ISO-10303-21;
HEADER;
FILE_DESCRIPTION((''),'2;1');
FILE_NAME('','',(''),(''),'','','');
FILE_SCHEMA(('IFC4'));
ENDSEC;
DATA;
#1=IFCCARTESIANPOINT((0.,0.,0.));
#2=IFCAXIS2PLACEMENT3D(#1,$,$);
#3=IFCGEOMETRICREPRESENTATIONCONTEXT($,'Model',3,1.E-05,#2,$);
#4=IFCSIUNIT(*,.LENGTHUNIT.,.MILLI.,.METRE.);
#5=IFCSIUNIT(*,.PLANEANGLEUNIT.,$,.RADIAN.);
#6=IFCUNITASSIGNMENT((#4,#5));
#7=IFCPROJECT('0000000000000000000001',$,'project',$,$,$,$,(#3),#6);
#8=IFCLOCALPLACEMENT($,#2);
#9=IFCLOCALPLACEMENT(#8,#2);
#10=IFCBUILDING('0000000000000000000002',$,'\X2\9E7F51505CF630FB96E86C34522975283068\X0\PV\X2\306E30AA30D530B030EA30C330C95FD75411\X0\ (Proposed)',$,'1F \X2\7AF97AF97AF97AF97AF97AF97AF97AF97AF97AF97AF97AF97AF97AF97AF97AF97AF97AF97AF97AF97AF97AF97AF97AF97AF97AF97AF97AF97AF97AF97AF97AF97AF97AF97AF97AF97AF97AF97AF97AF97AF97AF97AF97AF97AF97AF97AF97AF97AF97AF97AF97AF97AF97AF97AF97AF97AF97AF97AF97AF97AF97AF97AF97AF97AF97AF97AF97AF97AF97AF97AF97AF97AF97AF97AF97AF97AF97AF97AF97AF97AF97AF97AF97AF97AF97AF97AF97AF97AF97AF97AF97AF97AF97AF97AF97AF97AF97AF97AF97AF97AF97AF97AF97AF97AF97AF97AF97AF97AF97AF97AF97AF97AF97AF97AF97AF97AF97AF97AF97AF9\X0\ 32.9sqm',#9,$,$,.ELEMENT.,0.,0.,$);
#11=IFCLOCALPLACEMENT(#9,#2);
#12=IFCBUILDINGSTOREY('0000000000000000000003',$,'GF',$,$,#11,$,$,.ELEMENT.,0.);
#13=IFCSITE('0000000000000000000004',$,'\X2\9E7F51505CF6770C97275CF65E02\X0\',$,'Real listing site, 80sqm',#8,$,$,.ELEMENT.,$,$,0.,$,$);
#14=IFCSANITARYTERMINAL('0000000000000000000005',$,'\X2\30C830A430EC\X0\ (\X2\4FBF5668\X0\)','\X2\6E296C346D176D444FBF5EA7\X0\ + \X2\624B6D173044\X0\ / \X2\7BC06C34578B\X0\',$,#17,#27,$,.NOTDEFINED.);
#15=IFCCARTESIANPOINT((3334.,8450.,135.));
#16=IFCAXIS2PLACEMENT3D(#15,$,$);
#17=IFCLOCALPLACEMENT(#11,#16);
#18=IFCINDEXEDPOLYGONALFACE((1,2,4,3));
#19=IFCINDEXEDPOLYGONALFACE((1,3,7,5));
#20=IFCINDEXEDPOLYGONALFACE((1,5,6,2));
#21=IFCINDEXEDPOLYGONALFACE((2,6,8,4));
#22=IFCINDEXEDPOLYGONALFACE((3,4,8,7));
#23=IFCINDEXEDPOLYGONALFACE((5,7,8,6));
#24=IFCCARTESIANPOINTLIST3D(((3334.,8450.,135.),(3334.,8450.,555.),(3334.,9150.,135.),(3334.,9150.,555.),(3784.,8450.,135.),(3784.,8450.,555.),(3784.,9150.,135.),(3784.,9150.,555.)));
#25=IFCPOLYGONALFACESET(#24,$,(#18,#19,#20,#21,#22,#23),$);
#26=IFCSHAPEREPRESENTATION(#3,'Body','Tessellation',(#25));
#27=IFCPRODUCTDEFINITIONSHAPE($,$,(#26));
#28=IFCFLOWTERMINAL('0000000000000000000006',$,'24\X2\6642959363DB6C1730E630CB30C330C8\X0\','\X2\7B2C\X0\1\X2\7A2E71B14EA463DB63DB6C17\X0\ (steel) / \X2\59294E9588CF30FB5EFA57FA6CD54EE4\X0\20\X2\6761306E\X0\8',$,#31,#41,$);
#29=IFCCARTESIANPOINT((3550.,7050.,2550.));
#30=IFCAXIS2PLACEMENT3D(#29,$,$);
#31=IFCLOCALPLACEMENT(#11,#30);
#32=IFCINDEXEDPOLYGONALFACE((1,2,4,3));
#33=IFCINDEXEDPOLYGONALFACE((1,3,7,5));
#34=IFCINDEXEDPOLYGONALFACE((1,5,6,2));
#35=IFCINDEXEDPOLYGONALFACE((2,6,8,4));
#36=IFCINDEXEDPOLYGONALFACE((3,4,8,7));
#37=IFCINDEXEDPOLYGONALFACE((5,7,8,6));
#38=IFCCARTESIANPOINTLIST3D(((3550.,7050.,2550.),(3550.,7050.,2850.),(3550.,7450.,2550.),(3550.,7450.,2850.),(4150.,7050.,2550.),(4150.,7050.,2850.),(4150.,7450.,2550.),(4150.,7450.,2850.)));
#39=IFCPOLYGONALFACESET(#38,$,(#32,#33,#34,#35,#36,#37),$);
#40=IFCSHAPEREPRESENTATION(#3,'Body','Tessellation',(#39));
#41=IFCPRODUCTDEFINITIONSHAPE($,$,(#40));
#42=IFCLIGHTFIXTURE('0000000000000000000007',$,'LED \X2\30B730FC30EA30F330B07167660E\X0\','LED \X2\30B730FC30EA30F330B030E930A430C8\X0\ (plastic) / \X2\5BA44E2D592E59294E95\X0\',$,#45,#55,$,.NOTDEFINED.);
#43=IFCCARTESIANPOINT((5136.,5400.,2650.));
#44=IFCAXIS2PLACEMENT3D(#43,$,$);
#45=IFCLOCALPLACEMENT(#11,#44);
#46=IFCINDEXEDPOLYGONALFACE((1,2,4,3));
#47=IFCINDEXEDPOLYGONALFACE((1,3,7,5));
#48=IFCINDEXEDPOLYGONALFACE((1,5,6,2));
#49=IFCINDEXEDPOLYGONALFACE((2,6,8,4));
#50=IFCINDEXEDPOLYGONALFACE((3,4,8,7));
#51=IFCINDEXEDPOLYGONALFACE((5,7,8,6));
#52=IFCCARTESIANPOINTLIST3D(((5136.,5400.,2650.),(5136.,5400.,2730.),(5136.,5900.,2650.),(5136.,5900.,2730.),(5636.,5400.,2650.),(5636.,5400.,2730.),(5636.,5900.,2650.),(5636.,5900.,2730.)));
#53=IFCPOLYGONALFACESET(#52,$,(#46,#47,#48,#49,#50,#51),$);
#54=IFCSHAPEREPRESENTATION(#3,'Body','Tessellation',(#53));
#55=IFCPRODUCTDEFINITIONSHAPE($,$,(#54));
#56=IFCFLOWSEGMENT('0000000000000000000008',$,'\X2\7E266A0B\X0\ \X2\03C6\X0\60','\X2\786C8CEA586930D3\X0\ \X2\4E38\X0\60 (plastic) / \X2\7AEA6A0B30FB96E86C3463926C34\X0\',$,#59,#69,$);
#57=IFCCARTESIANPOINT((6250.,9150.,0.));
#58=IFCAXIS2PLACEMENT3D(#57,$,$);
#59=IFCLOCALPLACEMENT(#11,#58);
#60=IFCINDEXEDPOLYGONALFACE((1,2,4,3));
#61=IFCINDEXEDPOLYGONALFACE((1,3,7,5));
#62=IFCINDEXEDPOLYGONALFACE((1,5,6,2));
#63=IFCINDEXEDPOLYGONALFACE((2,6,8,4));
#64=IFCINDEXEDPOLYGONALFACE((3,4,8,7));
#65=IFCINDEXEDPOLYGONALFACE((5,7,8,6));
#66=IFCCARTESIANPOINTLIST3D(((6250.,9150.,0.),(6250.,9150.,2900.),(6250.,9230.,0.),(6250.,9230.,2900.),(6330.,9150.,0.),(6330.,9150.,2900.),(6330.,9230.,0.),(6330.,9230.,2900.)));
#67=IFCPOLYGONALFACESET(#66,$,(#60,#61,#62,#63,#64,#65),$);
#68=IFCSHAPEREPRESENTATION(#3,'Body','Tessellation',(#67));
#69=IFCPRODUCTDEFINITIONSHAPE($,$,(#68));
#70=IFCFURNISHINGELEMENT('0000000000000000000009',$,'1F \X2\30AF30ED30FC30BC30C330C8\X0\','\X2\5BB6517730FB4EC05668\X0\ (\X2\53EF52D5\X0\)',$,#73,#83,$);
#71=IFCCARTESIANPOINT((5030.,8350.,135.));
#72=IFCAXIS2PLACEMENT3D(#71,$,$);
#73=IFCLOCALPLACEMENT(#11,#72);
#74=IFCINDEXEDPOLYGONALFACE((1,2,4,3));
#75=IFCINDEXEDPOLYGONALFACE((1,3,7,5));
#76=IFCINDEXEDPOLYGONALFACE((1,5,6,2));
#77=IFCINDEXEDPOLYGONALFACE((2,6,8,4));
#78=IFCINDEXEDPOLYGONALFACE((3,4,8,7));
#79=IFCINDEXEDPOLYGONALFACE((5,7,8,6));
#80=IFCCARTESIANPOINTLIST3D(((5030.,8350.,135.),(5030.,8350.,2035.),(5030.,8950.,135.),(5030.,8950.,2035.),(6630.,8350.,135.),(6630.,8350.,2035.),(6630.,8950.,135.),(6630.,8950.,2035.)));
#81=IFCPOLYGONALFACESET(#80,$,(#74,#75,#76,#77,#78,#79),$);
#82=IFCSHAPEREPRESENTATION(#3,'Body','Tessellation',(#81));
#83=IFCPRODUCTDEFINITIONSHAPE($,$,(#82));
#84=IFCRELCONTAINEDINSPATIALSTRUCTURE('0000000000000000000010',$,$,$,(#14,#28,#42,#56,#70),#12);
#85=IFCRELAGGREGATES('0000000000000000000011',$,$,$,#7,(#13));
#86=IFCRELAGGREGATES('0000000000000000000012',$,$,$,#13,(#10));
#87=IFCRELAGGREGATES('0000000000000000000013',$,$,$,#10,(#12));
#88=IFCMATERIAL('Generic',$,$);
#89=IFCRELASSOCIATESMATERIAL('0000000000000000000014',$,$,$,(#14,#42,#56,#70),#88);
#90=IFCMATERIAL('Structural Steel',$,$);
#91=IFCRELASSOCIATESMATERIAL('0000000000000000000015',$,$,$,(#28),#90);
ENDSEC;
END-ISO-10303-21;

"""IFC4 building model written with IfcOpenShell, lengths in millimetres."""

from ifc_helpers import new_model, si_unit, frame, frame_2d, origin, place, context, project, spatial, rectangle, extrude, material, element, save


model = new_model("IFC4")

# Units and contexts
model_context = context("Model", 3, precision=1e-05, world=origin())
ifc_project = project(units=[si_unit("LENGTHUNIT", "METRE", prefix="MILLI"), si_unit("PLANEANGLEUNIT", "RADIAN")], contexts=[model_context])

# Site, building, storey
site_placement = place(None, origin())
site = spatial("IfcSite", under=ifc_project, at=site_placement, Name="鹿児島県霧島市", ObjectType="Real listing site, 80sqm", CompositionType="ELEMENT", RefElevation=0.0)
building_placement = place(site_placement, origin())
building = spatial("IfcBuilding", under=site, at=building_placement, Name="鹿児島・雨水利用とPVのオフグリッド志向 (Proposed)", ObjectType="1F 竹竹竹竹竹竹竹竹竹竹竹竹竹竹竹竹竹竹竹竹竹竹竹竹竹竹竹竹竹竹竹竹竹竹竹竹竹竹竹竹竹竹竹竹竹竹竹竹竹竹竹竹竹竹竹竹竹竹竹竹竹竹竹竹竹竹竹竹竹竹竹竹竹竹竹竹竹竹竹竹竹竹竹竹竹竹竹竹竹竹竹竹竹竹竹竹竹竹竹竹竹竹竹竹竹竹竹竹竹竹竹竹竹竹竹竹竹竹竹竹 32.9sqm", CompositionType="ELEMENT", ElevationOfRefHeight=0.0, ElevationOfTerrain=0.0)
storey_placement = place(building_placement, origin())
storey = spatial("IfcBuildingStorey", under=building, at=storey_placement, Name="GF", CompositionType="ELEMENT", Elevation=0.0)

# Shared definitions
ifc_material_1 = material(Name="Generic")

# Sanitary terminal
sanitary_terminal_placement = place(storey_placement, frame((3334.0, 8450.0, 135.0)))
element("IfcSanitaryTerminal", 1, at=sanitary_terminal_placement, inside=storey, material=ifc_material_1, Name="トイレ (便器)", Description="温水洗浄便座 + 手洗い / 節水型", PredefinedType="NOTDEFINED", context=model_context, shape_type="SweptSolid", body=[
    extrude(rectangle(XDim=450.0, YDim=700.0, at=frame_2d((225.0, 350.0))), frame((3334.0, 8450.0, 135.0)), (0.0, 0.0, 1.0), 420.0),
])

# Flow terminal
ifc_material_2 = material(Name="Structural Steel")
flow_terminal_placement = place(storey_placement, frame((3550.0, 7050.0, 2550.0)))
element("IfcFlowTerminal", 2, at=flow_terminal_placement, inside=storey, material=ifc_material_2, Name="24時間換気ユニット", Description="第1種熱交換換気 (steel) / 天井裏・建基法令20条の8", context=model_context, shape_type="SweptSolid", body=[
    extrude(rectangle(XDim=600.0, YDim=400.0, at=frame_2d((300.0, 200.0))), frame((3550.0, 7050.0, 2550.0)), (0.0, 0.0, 1.0), 300.0),
])

# Light fixture
light_fixture_placement = place(storey_placement, frame((5136.0, 5400.0, 2650.0)))
element("IfcLightFixture", 3, at=light_fixture_placement, inside=storey, material=ifc_material_1, Name="LED シーリング照明", Description="LED シーリングライト (plastic) / 室中央天井", PredefinedType="NOTDEFINED", context=model_context, shape_type="SweptSolid", body=[
    extrude(rectangle(XDim=500.0, YDim=500.0, at=frame_2d((250.0, 250.0))), frame((5136.0, 5400.0, 2650.0)), (0.0, 0.0, 1.0), 80.0),
])

# Flow segment
flow_segment_placement = place(storey_placement, frame((6250.0, 9150.0, 0.0)))
element("IfcFlowSegment", 4, at=flow_segment_placement, inside=storey, material=ifc_material_1, Name="縦樋 φ60", Description="硬質塩ビ 丸60 (plastic) / 竪樋・雨水排水", context=model_context, shape_type="SweptSolid", body=[
    extrude(rectangle(XDim=80.0, YDim=80.0, at=frame_2d((40.0, 40.0))), frame((6250.0, 9150.0, 0.0)), (0.0, 0.0, 1.0), 2900.0),
])

# Furnishing element
furnishing_placement = place(storey_placement, frame((5030.0, 8350.0, 135.0)))
element("IfcFurnishingElement", 5, at=furnishing_placement, inside=storey, material=ifc_material_1, Name="1F クローゼット", Description="家具・什器 (可動)", context=model_context, shape_type="SweptSolid", body=[
    extrude(rectangle(XDim=1600.0, YDim=600.0, at=frame_2d((800.0, 300.0))), frame((5030.0, 8350.0, 135.0)), (0.0, 0.0, 1.0), 1900.0),
])

save(model, "model.ifc")
